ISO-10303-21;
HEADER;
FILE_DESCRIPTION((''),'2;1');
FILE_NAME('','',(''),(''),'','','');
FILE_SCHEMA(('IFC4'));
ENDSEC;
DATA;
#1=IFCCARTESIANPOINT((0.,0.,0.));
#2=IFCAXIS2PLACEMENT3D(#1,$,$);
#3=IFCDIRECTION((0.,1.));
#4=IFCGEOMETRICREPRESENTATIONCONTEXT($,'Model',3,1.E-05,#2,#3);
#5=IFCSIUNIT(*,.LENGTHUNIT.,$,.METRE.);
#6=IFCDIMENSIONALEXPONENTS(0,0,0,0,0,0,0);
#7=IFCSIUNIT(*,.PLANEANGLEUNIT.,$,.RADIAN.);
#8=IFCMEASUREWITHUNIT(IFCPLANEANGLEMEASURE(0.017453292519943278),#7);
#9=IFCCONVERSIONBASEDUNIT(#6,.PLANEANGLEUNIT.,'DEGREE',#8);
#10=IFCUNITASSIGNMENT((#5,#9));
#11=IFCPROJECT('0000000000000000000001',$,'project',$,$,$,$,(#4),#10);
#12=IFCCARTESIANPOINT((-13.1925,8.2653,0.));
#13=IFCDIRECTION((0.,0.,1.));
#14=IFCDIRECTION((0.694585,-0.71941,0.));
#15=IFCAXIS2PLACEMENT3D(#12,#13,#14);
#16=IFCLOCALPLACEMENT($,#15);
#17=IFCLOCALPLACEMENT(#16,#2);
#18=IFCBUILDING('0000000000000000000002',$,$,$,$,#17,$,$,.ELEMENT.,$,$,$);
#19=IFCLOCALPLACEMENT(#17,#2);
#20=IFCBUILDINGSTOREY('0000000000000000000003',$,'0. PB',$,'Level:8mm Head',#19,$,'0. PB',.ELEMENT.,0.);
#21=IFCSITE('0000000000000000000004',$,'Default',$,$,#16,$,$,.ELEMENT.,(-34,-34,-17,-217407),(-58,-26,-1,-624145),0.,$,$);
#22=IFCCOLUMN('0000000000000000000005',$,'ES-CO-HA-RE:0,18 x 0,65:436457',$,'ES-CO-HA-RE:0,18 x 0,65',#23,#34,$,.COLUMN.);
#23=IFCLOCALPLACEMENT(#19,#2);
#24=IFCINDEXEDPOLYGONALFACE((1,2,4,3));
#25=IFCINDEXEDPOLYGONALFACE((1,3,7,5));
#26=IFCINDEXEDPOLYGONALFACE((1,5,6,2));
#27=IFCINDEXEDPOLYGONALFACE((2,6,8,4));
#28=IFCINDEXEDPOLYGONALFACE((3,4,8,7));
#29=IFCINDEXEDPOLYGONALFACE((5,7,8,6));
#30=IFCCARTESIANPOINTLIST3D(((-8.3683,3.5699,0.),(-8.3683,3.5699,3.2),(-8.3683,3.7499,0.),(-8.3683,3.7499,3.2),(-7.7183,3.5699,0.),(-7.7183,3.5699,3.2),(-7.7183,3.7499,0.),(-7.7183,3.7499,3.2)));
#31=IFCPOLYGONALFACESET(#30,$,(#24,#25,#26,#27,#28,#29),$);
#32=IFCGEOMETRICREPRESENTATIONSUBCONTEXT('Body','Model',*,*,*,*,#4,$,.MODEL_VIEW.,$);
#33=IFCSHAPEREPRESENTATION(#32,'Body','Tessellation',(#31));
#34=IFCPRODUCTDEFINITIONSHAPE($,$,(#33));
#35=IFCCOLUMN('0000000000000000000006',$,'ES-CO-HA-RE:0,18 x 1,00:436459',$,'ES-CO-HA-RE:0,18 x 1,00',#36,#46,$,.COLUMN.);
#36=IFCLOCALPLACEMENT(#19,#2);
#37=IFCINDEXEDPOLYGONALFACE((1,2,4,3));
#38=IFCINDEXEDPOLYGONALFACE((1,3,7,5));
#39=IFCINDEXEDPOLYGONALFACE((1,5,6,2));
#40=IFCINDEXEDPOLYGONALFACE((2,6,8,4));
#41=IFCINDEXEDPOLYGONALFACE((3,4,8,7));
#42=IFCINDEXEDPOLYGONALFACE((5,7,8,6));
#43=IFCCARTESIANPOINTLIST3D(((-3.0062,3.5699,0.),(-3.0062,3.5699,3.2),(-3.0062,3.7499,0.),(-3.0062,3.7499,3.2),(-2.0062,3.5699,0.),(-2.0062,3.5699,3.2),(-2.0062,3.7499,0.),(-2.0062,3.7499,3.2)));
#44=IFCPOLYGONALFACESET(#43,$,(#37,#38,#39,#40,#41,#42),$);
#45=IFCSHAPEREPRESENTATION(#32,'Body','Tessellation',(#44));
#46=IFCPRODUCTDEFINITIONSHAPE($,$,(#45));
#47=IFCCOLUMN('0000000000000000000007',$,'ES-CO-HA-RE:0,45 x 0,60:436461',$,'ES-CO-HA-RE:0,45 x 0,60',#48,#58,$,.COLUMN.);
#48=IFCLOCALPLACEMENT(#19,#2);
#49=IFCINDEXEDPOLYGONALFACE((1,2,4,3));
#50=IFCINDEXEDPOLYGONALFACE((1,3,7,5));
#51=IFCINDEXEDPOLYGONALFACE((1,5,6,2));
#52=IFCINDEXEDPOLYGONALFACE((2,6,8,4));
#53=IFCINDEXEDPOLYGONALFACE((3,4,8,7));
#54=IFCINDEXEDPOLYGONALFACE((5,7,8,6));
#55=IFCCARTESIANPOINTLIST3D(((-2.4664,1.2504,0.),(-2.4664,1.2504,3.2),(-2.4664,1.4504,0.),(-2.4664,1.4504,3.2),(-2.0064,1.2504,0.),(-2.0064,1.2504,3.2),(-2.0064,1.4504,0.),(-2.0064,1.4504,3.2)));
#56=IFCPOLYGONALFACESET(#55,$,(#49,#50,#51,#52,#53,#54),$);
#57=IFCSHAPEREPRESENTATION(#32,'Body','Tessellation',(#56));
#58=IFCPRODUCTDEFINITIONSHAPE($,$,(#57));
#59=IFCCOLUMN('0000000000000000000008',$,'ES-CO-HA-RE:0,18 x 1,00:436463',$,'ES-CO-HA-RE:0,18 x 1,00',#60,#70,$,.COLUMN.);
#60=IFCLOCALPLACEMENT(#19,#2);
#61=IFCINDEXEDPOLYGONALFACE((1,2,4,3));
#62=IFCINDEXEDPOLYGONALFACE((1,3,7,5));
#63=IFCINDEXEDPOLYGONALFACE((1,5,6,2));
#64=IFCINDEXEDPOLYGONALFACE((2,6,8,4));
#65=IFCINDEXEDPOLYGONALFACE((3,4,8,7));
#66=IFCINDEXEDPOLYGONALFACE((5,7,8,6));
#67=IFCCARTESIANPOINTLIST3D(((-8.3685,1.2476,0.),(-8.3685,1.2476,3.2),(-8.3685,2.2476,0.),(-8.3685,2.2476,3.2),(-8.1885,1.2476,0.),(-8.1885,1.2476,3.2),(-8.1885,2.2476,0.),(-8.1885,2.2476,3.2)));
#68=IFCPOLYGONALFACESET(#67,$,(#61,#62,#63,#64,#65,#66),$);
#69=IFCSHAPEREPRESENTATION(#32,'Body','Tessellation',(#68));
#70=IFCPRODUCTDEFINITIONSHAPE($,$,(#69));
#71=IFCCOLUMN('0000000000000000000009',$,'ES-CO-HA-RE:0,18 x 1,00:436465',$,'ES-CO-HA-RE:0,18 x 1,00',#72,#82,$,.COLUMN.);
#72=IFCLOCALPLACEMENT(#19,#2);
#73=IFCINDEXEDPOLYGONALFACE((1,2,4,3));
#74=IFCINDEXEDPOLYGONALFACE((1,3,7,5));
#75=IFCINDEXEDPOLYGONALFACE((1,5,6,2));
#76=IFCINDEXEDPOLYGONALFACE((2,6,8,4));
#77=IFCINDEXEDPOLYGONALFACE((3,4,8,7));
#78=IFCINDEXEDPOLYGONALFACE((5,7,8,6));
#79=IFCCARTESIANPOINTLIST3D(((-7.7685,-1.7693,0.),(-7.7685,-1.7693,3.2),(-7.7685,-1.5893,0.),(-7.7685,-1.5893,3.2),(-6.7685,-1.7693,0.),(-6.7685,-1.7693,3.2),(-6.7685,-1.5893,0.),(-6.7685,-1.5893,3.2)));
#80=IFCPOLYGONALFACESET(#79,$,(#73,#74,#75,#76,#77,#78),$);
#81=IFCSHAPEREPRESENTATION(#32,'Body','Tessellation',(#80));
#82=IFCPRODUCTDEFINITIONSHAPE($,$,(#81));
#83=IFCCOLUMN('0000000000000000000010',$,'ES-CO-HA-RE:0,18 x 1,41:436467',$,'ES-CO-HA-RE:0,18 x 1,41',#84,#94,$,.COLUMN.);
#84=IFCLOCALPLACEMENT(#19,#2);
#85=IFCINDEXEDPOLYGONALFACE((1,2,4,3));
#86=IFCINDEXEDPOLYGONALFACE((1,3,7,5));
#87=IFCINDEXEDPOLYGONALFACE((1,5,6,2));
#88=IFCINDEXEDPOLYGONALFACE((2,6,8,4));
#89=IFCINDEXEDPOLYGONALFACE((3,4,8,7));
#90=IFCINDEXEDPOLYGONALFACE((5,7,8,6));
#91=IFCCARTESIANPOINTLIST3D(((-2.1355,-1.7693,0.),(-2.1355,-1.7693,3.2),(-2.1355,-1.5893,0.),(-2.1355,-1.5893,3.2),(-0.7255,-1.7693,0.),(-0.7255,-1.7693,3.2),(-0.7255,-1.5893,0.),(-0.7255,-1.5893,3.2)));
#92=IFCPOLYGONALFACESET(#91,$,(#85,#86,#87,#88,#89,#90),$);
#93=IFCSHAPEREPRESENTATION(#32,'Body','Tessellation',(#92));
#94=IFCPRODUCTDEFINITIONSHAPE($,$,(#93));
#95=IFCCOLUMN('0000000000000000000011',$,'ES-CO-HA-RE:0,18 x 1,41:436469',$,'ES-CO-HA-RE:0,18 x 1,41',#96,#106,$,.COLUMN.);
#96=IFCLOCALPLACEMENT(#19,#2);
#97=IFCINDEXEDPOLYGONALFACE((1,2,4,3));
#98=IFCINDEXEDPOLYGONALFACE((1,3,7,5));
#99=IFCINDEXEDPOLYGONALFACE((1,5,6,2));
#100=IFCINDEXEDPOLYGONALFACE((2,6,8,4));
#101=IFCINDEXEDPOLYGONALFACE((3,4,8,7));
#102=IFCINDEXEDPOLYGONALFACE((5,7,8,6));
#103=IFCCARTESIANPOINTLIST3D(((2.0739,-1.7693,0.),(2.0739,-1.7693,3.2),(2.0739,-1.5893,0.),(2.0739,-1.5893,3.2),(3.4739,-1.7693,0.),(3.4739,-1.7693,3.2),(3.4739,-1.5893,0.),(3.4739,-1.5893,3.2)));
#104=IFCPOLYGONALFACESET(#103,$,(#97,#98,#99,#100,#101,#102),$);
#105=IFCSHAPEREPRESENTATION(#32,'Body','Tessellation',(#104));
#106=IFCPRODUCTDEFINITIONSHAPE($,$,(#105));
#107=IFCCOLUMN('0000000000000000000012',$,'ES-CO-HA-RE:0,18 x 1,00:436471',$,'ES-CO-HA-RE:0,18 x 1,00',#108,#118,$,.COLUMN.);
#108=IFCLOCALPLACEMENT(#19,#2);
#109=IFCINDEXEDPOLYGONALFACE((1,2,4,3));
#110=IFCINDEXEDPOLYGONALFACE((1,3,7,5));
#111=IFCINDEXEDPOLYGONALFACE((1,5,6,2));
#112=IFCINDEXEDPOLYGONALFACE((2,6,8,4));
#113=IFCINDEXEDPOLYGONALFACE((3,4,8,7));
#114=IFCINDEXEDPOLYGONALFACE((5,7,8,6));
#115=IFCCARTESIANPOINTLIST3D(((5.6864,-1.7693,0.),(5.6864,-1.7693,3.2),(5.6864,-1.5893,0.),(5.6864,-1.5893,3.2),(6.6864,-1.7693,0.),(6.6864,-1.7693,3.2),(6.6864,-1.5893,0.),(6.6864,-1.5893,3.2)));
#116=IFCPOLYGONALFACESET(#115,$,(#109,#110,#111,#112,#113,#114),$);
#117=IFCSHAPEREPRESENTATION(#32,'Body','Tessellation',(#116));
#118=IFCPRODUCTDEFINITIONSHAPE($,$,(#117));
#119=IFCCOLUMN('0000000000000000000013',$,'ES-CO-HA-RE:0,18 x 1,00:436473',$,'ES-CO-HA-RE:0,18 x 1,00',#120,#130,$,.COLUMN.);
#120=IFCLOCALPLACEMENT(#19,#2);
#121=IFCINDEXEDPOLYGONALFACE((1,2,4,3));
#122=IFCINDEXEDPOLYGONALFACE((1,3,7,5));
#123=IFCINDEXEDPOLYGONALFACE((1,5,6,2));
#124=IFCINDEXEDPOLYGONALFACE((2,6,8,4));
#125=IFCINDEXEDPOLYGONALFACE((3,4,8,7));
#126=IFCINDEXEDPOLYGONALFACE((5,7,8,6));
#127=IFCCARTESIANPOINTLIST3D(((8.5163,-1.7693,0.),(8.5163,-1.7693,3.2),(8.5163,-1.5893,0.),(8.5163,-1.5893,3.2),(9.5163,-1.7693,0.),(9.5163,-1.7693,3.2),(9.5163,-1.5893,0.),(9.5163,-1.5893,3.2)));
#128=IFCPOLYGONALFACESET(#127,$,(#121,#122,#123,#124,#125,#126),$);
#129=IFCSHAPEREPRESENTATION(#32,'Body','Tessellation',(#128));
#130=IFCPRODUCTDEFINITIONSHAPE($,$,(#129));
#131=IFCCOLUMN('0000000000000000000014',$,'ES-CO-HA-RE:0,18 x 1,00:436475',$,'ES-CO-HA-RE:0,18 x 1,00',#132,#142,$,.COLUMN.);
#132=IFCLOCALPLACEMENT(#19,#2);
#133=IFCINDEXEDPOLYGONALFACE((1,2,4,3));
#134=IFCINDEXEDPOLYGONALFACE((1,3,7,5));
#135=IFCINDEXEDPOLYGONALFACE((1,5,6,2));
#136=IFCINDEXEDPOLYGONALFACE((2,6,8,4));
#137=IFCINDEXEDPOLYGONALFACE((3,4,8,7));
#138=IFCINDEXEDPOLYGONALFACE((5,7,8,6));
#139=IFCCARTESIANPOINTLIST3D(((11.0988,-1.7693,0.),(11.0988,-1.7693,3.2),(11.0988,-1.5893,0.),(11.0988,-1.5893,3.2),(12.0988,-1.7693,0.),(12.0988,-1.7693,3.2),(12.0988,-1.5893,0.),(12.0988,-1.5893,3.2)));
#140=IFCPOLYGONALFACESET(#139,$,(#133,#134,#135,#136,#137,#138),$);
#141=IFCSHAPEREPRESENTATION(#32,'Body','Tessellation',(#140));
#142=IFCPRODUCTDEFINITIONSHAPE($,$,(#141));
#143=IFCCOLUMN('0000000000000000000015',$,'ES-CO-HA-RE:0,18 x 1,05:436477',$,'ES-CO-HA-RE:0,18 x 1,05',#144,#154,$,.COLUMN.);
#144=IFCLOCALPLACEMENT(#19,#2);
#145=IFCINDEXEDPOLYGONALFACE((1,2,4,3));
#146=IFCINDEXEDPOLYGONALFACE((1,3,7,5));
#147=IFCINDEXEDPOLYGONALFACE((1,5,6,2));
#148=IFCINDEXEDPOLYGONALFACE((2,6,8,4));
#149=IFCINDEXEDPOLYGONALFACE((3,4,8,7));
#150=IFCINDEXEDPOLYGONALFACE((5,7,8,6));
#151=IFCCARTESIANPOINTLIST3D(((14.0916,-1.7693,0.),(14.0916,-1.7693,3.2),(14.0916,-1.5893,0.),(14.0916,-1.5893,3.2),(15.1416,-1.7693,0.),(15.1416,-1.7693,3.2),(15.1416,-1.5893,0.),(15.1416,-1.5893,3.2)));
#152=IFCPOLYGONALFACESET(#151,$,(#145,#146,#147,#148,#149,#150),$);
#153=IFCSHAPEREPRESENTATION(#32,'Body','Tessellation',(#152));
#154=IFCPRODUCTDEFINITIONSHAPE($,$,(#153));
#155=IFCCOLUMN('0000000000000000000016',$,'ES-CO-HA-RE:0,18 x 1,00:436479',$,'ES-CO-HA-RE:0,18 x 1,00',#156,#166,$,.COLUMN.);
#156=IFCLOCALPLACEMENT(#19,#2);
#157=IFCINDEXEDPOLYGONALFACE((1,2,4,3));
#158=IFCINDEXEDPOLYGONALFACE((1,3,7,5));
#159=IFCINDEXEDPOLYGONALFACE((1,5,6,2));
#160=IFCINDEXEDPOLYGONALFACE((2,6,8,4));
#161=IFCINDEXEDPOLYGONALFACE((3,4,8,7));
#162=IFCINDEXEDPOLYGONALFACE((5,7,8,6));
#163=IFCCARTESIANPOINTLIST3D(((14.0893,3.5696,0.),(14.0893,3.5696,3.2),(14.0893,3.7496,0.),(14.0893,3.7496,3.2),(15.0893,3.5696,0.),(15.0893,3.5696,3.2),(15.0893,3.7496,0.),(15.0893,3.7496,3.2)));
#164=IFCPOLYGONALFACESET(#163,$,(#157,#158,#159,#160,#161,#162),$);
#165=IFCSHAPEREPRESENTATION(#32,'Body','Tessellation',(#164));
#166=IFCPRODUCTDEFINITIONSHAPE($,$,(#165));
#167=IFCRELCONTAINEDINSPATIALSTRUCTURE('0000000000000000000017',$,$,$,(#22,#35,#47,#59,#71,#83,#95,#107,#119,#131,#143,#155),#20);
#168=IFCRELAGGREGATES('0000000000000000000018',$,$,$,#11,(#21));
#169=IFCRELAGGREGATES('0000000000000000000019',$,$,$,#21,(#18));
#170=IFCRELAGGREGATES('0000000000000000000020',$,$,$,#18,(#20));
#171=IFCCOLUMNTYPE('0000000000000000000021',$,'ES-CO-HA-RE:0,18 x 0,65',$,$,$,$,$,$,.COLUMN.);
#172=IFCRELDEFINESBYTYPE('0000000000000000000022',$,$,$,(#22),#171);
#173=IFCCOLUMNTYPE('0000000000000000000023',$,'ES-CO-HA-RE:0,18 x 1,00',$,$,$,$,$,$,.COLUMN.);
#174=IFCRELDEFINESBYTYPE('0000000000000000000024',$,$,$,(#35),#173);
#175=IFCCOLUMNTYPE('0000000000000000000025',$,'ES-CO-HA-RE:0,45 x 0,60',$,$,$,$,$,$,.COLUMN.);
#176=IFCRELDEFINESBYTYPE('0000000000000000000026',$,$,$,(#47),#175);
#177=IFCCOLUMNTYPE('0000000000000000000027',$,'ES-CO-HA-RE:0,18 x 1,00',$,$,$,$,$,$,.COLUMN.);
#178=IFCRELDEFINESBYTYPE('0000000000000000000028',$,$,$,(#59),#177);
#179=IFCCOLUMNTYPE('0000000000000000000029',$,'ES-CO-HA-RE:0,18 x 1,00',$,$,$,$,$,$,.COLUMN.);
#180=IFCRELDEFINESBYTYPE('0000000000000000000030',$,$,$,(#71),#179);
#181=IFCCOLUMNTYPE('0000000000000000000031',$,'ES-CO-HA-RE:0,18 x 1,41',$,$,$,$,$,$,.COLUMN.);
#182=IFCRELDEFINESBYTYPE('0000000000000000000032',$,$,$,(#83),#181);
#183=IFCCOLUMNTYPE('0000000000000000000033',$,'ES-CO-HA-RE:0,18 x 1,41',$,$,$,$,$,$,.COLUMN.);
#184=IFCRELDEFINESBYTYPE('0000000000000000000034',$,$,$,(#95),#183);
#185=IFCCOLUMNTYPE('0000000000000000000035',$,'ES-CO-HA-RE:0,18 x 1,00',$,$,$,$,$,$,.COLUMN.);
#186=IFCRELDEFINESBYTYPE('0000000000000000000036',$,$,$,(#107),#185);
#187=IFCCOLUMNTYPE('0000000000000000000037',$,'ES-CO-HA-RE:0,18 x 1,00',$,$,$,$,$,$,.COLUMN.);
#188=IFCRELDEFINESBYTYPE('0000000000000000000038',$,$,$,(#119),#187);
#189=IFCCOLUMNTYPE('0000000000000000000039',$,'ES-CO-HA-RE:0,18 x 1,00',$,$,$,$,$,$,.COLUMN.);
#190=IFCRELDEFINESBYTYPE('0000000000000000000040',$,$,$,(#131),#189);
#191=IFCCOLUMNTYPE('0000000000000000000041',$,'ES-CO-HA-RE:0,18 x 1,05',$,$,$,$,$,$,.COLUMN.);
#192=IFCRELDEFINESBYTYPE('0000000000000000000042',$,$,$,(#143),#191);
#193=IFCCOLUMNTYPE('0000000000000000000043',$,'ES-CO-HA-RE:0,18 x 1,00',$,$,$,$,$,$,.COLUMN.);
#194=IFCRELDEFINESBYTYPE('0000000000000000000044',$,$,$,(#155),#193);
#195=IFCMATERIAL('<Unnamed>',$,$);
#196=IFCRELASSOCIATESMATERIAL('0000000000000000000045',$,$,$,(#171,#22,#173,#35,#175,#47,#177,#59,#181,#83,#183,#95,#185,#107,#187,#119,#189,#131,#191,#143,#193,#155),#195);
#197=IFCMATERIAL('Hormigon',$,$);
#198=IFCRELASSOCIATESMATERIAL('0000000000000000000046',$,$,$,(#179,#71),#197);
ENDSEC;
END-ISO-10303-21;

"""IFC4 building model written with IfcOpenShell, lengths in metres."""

from ifc_helpers import new_model, entity, si_unit, converted_unit, direction, frame, origin, place, context, subcontext, project, spatial, indexed_curve, outline, extrude, source, transform, mapped, material, type_object, type_shapes, element, save


model = new_model("IFC4")

# Units and contexts
model_context = context("Model", 3, precision=1e-05, world=origin(), true_north=direction((0.0, 1.0)))
body_context = subcontext(model_context, "Body", "Model", "MODEL_VIEW")
ifc_project = project(units=[si_unit("LENGTHUNIT", "METRE"), converted_unit("PLANEANGLEUNIT", "DEGREE", entity("IfcPlaneAngleMeasure", 0.017453292519943278), si_unit("PLANEANGLEUNIT", "RADIAN"), dimensions=[0, 0, 0, 0, 0, 0, 0])], contexts=[model_context])

# Site, building, storey
site_placement = place(None, frame((-13.1925, 8.2653, 0.0), z_axis=(0.0, 0.0, 1.0), x_axis=(0.694585, -0.71941, 0.0)))
site = spatial("IfcSite", under=ifc_project, at=site_placement, Name="Default", CompositionType="ELEMENT", RefLatitude=(-34, -34, -17, -217407), RefLongitude=(-58, -26, -1, -624145), RefElevation=0.0)
building_placement = place(site_placement, origin())
building = spatial("IfcBuilding", under=site, at=building_placement, CompositionType="ELEMENT")
storey_placement = place(building_placement, origin())
storey = spatial("IfcBuildingStorey", under=building, at=storey_placement, Name="0. PB", ObjectType="Level:8mm Head", LongName="0. PB", CompositionType="ELEMENT", Elevation=0.0)

# Columns
ifc_material_1 = material(Name="<Unnamed>")
column_type_1 = type_object("IfcColumnType", Name="ES-CO-HA-RE:0,18 x 0,65", PredefinedType="COLUMN", material=ifc_material_1)
shared_shape_1 = source(origin(), body_context, "Body", "SweptSolid", [
    extrude(outline(indexed_curve([(-0.325, -0.09), (0.325, -0.09), (0.325, 0.09), (-0.325, 0.09), (-0.325, -0.09)], self_intersect=False)), frame((-8.0433, 3.6599, 0.0), z_axis=(0.0, 0.0, 1.0), x_axis=(-1.0, 0.0, 0.0)), (0.0, 0.0, 1.0), 3.2),
])
type_shapes(column_type_1, [shared_shape_1])
column_1_placement = place(storey_placement, origin())
element("IfcColumn", 1, at=column_1_placement, inside=storey, type_object=column_type_1, material=ifc_material_1, Name="ES-CO-HA-RE:0,18 x 0,65:436457", ObjectType="ES-CO-HA-RE:0,18 x 0,65", PredefinedType="COLUMN", context=body_context, shape_type="MappedRepresentation", body=[
    mapped(shared_shape_1, transform((0.0, 0.0, 0.0), scale=1.0)),
])
column_type_2 = type_object("IfcColumnType", Name="ES-CO-HA-RE:0,18 x 1,00", PredefinedType="COLUMN", material=ifc_material_1)
shared_shape_2 = source(origin(), body_context, "Body", "SweptSolid", [
    extrude(outline(indexed_curve([(-0.5, -0.09), (0.5, -0.09), (0.5, 0.09), (-0.5, 0.09), (-0.5, -0.09)], self_intersect=False)), frame((-2.5062, 3.6599, 0.0), z_axis=(0.0, 0.0, 1.0), x_axis=(-1.0, 0.0, 0.0)), (0.0, 0.0, 1.0), 3.2),
])
type_shapes(column_type_2, [shared_shape_2])
column_2_placement = place(storey_placement, origin())
element("IfcColumn", 2, at=column_2_placement, inside=storey, type_object=column_type_2, material=ifc_material_1, Name="ES-CO-HA-RE:0,18 x 1,00:436459", ObjectType="ES-CO-HA-RE:0,18 x 1,00", PredefinedType="COLUMN", context=body_context, shape_type="MappedRepresentation", body=[
    mapped(shared_shape_2, transform((0.0, 0.0, 0.0), scale=1.0)),
])
column_type_3 = type_object("IfcColumnType", Name="ES-CO-HA-RE:0,45 x 0,60", PredefinedType="COLUMN", material=ifc_material_1)
shared_shape_3 = source(origin(), body_context, "Body", "SweptSolid", [
    extrude(outline(indexed_curve([(-0.23, -0.1), (0.23, -0.1), (0.23, 0.1), (-0.23, 0.1), (-0.23, -0.1)], self_intersect=False)), frame((-2.2364, 1.3504, 0.0), z_axis=(0.0, 0.0, 1.0), x_axis=(-1.0, 0.0, 0.0)), (0.0, 0.0, 1.0), 3.2),
])
type_shapes(column_type_3, [shared_shape_3])
column_3_placement = place(storey_placement, origin())
element("IfcColumn", 3, at=column_3_placement, inside=storey, type_object=column_type_3, material=ifc_material_1, Name="ES-CO-HA-RE:0,45 x 0,60:436461", ObjectType="ES-CO-HA-RE:0,45 x 0,60", PredefinedType="COLUMN", context=body_context, shape_type="MappedRepresentation", body=[
    mapped(shared_shape_3, transform((0.0, 0.0, 0.0), scale=1.0)),
])
column_type_4 = type_object("IfcColumnType", Name="ES-CO-HA-RE:0,18 x 1,00", PredefinedType="COLUMN", material=ifc_material_1)
shared_shape_4 = source(origin(), body_context, "Body", "SweptSolid", [
    extrude(outline(indexed_curve([(-0.5, -0.09), (0.5, -0.09), (0.5, 0.09), (-0.5, 0.09), (-0.5, -0.09)], self_intersect=False)), frame((-8.2785, 1.7476, 0.0), z_axis=(0.0, 0.0, 1.0), x_axis=(0.0, -1.0, 0.0)), (0.0, 0.0, 1.0), 3.2),
])
type_shapes(column_type_4, [shared_shape_4])
column_4_placement = place(storey_placement, origin())
element("IfcColumn", 4, at=column_4_placement, inside=storey, type_object=column_type_4, material=ifc_material_1, Name="ES-CO-HA-RE:0,18 x 1,00:436463", ObjectType="ES-CO-HA-RE:0,18 x 1,00", PredefinedType="COLUMN", context=body_context, shape_type="MappedRepresentation", body=[
    mapped(shared_shape_4, transform((0.0, 0.0, 0.0), scale=1.0)),
])
ifc_material_2 = material(Name="Hormigon")
column_type_5 = type_object("IfcColumnType", Name="ES-CO-HA-RE:0,18 x 1,00", PredefinedType="COLUMN", material=ifc_material_2)
shared_shape_5 = source(origin(), body_context, "Body", "SweptSolid", [
    extrude(outline(indexed_curve([(-0.5, -0.09), (0.5, -0.09), (0.5, 0.09), (-0.5, 0.09), (-0.5, -0.09)], self_intersect=False)), frame((-7.2685, -1.6793, 0.0), z_axis=(0.0, 0.0, 1.0), x_axis=(-1.0, 0.0, 0.0)), (0.0, 0.0, 1.0), 3.2),
])
type_shapes(column_type_5, [shared_shape_5])
column_5_placement = place(storey_placement, origin())
element("IfcColumn", 5, at=column_5_placement, inside=storey, type_object=column_type_5, material=ifc_material_2, Name="ES-CO-HA-RE:0,18 x 1,00:436465", ObjectType="ES-CO-HA-RE:0,18 x 1,00", PredefinedType="COLUMN", context=body_context, shape_type="MappedRepresentation", body=[
    mapped(shared_shape_5, transform((0.0, 0.0, 0.0), scale=1.0)),
])
column_type_6 = type_object("IfcColumnType", Name="ES-CO-HA-RE:0,18 x 1,41", PredefinedType="COLUMN", material=ifc_material_1)
shared_shape_6 = source(origin(), body_context, "Body", "SweptSolid", [
    extrude(outline(indexed_curve([(-0.705, -0.09), (0.705, -0.09), (0.705, 0.09), (-0.705, 0.09), (-0.705, -0.09)], self_intersect=False)), frame((-1.4305, -1.6793, 0.0), z_axis=(0.0, 0.0, 1.0), x_axis=(-1.0, 0.0, 0.0)), (0.0, 0.0, 1.0), 3.2),
])
type_shapes(column_type_6, [shared_shape_6])
column_6_placement = place(storey_placement, origin())
element("IfcColumn", 6, at=column_6_placement, inside=storey, type_object=column_type_6, material=ifc_material_1, Name="ES-CO-HA-RE:0,18 x 1,41:436467", ObjectType="ES-CO-HA-RE:0,18 x 1,41", PredefinedType="COLUMN", context=body_context, shape_type="MappedRepresentation", body=[
    mapped(shared_shape_6, transform((0.0, 0.0, 0.0), scale=1.0)),
])
column_type_7 = type_object("IfcColumnType", Name="ES-CO-HA-RE:0,18 x 1,41", PredefinedType="COLUMN", material=ifc_material_1)
shared_shape_7 = source(origin(), body_context, "Body", "SweptSolid", [
    extrude(outline(indexed_curve([(-0.7, -0.09), (0.7, -0.09), (0.7, 0.09), (-0.7, 0.09), (-0.7, -0.09)], self_intersect=False)), frame((2.7739, -1.6793, 0.0), z_axis=(0.0, 0.0, 1.0), x_axis=(-1.0, 0.0, 0.0)), (0.0, 0.0, 1.0), 3.2),
])
type_shapes(column_type_7, [shared_shape_7])
column_7_placement = place(storey_placement, origin())
element("IfcColumn", 7, at=column_7_placement, inside=storey, type_object=column_type_7, material=ifc_material_1, Name="ES-CO-HA-RE:0,18 x 1,41:436469", ObjectType="ES-CO-HA-RE:0,18 x 1,41", PredefinedType="COLUMN", context=body_context, shape_type="MappedRepresentation", body=[
    mapped(shared_shape_7, transform((0.0, 0.0, 0.0), scale=1.0)),
])
column_type_8 = type_object("IfcColumnType", Name="ES-CO-HA-RE:0,18 x 1,00", PredefinedType="COLUMN", material=ifc_material_1)
shared_shape_8 = source(origin(), body_context, "Body", "SweptSolid", [
    extrude(outline(indexed_curve([(-0.5, -0.09), (0.5, -0.09), (0.5, 0.09), (-0.5, 0.09), (-0.5, -0.09)], self_intersect=False)), frame((6.1864, -1.6793, 0.0), z_axis=(0.0, 0.0, 1.0), x_axis=(-1.0, 0.0, 0.0)), (0.0, 0.0, 1.0), 3.2),
])
type_shapes(column_type_8, [shared_shape_8])
column_8_placement = place(storey_placement, origin())
element("IfcColumn", 8, at=column_8_placement, inside=storey, type_object=column_type_8, material=ifc_material_1, Name="ES-CO-HA-RE:0,18 x 1,00:436471", ObjectType="ES-CO-HA-RE:0,18 x 1,00", PredefinedType="COLUMN", context=body_context, shape_type="MappedRepresentation", body=[
    mapped(shared_shape_8, transform((0.0, 0.0, 0.0), scale=1.0)),
])
column_type_9 = type_object("IfcColumnType", Name="ES-CO-HA-RE:0,18 x 1,00", PredefinedType="COLUMN", material=ifc_material_1)
shared_shape_9 = source(origin(), body_context, "Body", "SweptSolid", [
    extrude(outline(indexed_curve([(-0.5, -0.09), (0.5, -0.09), (0.5, 0.09), (-0.5, 0.09), (-0.5, -0.09)], self_intersect=False)), frame((9.0163, -1.6793, 0.0), z_axis=(0.0, 0.0, 1.0), x_axis=(-1.0, 0.0, 0.0)), (0.0, 0.0, 1.0), 3.2),
])
type_shapes(column_type_9, [shared_shape_9])
column_9_placement = place(storey_placement, origin())
element("IfcColumn", 9, at=column_9_placement, inside=storey, type_object=column_type_9, material=ifc_material_1, Name="ES-CO-HA-RE:0,18 x 1,00:436473", ObjectType="ES-CO-HA-RE:0,18 x 1,00", PredefinedType="COLUMN", context=body_context, shape_type="MappedRepresentation", body=[
    mapped(shared_shape_9, transform((0.0, 0.0, 0.0), scale=1.0)),
])
column_type_10 = type_object("IfcColumnType", Name="ES-CO-HA-RE:0,18 x 1,00", PredefinedType="COLUMN", material=ifc_material_1)
shared_shape_10 = source(origin(), body_context, "Body", "SweptSolid", [
    extrude(outline(indexed_curve([(-0.5, -0.09), (0.5, -0.09), (0.5, 0.09), (-0.5, 0.09), (-0.5, -0.09)], self_intersect=False)), frame((11.5988, -1.6793, 0.0), z_axis=(0.0, 0.0, 1.0), x_axis=(-1.0, 0.0, 0.0)), (0.0, 0.0, 1.0), 3.2),
])
type_shapes(column_type_10, [shared_shape_10])
column_10_placement = place(storey_placement, origin())
element("IfcColumn", 10, at=column_10_placement, inside=storey, type_object=column_type_10, material=ifc_material_1, Name="ES-CO-HA-RE:0,18 x 1,00:436475", ObjectType="ES-CO-HA-RE:0,18 x 1,00", PredefinedType="COLUMN", context=body_context, shape_type="MappedRepresentation", body=[
    mapped(shared_shape_10, transform((0.0, 0.0, 0.0), scale=1.0)),
])
column_type_11 = type_object("IfcColumnType", Name="ES-CO-HA-RE:0,18 x 1,05", PredefinedType="COLUMN", material=ifc_material_1)
shared_shape_11 = source(origin(), body_context, "Body", "SweptSolid", [
    extrude(outline(indexed_curve([(-0.525, -0.09), (0.525, -0.09), (0.525, 0.09), (-0.525, 0.09), (-0.525, -0.09)], self_intersect=False)), frame((14.6166, -1.6793, 0.0), z_axis=(0.0, 0.0, 1.0), x_axis=(-1.0, 0.0, 0.0)), (0.0, 0.0, 1.0), 3.2),
])
type_shapes(column_type_11, [shared_shape_11])
column_11_placement = place(storey_placement, origin())
element("IfcColumn", 11, at=column_11_placement, inside=storey, type_object=column_type_11, material=ifc_material_1, Name="ES-CO-HA-RE:0,18 x 1,05:436477", ObjectType="ES-CO-HA-RE:0,18 x 1,05", PredefinedType="COLUMN", context=body_context, shape_type="MappedRepresentation", body=[
    mapped(shared_shape_11, transform((0.0, 0.0, 0.0), scale=1.0)),
])
column_type_12 = type_object("IfcColumnType", Name="ES-CO-HA-RE:0,18 x 1,00", PredefinedType="COLUMN", material=ifc_material_1)
shared_shape_12 = source(origin(), body_context, "Body", "SweptSolid", [
    extrude(outline(indexed_curve([(-0.5, -0.09), (0.5, -0.09), (0.5, 0.09), (-0.5, 0.09), (-0.5, -0.09)], self_intersect=False)), frame((14.5893, 3.6596, 0.0), z_axis=(0.0, 0.0, 1.0), x_axis=(-1.0, 0.0, 0.0)), (0.0, 0.0, 1.0), 3.2),
])
type_shapes(column_type_12, [shared_shape_12])
column_12_placement = place(storey_placement, origin())
element("IfcColumn", 12, at=column_12_placement, inside=storey, type_object=column_type_12, material=ifc_material_1, Name="ES-CO-HA-RE:0,18 x 1,00:436479", ObjectType="ES-CO-HA-RE:0,18 x 1,00", PredefinedType="COLUMN", context=body_context, shape_type="MappedRepresentation", body=[
    mapped(shared_shape_12, transform((0.0, 0.0, 0.0), scale=1.0)),
])

save(model, "model.ifc")
